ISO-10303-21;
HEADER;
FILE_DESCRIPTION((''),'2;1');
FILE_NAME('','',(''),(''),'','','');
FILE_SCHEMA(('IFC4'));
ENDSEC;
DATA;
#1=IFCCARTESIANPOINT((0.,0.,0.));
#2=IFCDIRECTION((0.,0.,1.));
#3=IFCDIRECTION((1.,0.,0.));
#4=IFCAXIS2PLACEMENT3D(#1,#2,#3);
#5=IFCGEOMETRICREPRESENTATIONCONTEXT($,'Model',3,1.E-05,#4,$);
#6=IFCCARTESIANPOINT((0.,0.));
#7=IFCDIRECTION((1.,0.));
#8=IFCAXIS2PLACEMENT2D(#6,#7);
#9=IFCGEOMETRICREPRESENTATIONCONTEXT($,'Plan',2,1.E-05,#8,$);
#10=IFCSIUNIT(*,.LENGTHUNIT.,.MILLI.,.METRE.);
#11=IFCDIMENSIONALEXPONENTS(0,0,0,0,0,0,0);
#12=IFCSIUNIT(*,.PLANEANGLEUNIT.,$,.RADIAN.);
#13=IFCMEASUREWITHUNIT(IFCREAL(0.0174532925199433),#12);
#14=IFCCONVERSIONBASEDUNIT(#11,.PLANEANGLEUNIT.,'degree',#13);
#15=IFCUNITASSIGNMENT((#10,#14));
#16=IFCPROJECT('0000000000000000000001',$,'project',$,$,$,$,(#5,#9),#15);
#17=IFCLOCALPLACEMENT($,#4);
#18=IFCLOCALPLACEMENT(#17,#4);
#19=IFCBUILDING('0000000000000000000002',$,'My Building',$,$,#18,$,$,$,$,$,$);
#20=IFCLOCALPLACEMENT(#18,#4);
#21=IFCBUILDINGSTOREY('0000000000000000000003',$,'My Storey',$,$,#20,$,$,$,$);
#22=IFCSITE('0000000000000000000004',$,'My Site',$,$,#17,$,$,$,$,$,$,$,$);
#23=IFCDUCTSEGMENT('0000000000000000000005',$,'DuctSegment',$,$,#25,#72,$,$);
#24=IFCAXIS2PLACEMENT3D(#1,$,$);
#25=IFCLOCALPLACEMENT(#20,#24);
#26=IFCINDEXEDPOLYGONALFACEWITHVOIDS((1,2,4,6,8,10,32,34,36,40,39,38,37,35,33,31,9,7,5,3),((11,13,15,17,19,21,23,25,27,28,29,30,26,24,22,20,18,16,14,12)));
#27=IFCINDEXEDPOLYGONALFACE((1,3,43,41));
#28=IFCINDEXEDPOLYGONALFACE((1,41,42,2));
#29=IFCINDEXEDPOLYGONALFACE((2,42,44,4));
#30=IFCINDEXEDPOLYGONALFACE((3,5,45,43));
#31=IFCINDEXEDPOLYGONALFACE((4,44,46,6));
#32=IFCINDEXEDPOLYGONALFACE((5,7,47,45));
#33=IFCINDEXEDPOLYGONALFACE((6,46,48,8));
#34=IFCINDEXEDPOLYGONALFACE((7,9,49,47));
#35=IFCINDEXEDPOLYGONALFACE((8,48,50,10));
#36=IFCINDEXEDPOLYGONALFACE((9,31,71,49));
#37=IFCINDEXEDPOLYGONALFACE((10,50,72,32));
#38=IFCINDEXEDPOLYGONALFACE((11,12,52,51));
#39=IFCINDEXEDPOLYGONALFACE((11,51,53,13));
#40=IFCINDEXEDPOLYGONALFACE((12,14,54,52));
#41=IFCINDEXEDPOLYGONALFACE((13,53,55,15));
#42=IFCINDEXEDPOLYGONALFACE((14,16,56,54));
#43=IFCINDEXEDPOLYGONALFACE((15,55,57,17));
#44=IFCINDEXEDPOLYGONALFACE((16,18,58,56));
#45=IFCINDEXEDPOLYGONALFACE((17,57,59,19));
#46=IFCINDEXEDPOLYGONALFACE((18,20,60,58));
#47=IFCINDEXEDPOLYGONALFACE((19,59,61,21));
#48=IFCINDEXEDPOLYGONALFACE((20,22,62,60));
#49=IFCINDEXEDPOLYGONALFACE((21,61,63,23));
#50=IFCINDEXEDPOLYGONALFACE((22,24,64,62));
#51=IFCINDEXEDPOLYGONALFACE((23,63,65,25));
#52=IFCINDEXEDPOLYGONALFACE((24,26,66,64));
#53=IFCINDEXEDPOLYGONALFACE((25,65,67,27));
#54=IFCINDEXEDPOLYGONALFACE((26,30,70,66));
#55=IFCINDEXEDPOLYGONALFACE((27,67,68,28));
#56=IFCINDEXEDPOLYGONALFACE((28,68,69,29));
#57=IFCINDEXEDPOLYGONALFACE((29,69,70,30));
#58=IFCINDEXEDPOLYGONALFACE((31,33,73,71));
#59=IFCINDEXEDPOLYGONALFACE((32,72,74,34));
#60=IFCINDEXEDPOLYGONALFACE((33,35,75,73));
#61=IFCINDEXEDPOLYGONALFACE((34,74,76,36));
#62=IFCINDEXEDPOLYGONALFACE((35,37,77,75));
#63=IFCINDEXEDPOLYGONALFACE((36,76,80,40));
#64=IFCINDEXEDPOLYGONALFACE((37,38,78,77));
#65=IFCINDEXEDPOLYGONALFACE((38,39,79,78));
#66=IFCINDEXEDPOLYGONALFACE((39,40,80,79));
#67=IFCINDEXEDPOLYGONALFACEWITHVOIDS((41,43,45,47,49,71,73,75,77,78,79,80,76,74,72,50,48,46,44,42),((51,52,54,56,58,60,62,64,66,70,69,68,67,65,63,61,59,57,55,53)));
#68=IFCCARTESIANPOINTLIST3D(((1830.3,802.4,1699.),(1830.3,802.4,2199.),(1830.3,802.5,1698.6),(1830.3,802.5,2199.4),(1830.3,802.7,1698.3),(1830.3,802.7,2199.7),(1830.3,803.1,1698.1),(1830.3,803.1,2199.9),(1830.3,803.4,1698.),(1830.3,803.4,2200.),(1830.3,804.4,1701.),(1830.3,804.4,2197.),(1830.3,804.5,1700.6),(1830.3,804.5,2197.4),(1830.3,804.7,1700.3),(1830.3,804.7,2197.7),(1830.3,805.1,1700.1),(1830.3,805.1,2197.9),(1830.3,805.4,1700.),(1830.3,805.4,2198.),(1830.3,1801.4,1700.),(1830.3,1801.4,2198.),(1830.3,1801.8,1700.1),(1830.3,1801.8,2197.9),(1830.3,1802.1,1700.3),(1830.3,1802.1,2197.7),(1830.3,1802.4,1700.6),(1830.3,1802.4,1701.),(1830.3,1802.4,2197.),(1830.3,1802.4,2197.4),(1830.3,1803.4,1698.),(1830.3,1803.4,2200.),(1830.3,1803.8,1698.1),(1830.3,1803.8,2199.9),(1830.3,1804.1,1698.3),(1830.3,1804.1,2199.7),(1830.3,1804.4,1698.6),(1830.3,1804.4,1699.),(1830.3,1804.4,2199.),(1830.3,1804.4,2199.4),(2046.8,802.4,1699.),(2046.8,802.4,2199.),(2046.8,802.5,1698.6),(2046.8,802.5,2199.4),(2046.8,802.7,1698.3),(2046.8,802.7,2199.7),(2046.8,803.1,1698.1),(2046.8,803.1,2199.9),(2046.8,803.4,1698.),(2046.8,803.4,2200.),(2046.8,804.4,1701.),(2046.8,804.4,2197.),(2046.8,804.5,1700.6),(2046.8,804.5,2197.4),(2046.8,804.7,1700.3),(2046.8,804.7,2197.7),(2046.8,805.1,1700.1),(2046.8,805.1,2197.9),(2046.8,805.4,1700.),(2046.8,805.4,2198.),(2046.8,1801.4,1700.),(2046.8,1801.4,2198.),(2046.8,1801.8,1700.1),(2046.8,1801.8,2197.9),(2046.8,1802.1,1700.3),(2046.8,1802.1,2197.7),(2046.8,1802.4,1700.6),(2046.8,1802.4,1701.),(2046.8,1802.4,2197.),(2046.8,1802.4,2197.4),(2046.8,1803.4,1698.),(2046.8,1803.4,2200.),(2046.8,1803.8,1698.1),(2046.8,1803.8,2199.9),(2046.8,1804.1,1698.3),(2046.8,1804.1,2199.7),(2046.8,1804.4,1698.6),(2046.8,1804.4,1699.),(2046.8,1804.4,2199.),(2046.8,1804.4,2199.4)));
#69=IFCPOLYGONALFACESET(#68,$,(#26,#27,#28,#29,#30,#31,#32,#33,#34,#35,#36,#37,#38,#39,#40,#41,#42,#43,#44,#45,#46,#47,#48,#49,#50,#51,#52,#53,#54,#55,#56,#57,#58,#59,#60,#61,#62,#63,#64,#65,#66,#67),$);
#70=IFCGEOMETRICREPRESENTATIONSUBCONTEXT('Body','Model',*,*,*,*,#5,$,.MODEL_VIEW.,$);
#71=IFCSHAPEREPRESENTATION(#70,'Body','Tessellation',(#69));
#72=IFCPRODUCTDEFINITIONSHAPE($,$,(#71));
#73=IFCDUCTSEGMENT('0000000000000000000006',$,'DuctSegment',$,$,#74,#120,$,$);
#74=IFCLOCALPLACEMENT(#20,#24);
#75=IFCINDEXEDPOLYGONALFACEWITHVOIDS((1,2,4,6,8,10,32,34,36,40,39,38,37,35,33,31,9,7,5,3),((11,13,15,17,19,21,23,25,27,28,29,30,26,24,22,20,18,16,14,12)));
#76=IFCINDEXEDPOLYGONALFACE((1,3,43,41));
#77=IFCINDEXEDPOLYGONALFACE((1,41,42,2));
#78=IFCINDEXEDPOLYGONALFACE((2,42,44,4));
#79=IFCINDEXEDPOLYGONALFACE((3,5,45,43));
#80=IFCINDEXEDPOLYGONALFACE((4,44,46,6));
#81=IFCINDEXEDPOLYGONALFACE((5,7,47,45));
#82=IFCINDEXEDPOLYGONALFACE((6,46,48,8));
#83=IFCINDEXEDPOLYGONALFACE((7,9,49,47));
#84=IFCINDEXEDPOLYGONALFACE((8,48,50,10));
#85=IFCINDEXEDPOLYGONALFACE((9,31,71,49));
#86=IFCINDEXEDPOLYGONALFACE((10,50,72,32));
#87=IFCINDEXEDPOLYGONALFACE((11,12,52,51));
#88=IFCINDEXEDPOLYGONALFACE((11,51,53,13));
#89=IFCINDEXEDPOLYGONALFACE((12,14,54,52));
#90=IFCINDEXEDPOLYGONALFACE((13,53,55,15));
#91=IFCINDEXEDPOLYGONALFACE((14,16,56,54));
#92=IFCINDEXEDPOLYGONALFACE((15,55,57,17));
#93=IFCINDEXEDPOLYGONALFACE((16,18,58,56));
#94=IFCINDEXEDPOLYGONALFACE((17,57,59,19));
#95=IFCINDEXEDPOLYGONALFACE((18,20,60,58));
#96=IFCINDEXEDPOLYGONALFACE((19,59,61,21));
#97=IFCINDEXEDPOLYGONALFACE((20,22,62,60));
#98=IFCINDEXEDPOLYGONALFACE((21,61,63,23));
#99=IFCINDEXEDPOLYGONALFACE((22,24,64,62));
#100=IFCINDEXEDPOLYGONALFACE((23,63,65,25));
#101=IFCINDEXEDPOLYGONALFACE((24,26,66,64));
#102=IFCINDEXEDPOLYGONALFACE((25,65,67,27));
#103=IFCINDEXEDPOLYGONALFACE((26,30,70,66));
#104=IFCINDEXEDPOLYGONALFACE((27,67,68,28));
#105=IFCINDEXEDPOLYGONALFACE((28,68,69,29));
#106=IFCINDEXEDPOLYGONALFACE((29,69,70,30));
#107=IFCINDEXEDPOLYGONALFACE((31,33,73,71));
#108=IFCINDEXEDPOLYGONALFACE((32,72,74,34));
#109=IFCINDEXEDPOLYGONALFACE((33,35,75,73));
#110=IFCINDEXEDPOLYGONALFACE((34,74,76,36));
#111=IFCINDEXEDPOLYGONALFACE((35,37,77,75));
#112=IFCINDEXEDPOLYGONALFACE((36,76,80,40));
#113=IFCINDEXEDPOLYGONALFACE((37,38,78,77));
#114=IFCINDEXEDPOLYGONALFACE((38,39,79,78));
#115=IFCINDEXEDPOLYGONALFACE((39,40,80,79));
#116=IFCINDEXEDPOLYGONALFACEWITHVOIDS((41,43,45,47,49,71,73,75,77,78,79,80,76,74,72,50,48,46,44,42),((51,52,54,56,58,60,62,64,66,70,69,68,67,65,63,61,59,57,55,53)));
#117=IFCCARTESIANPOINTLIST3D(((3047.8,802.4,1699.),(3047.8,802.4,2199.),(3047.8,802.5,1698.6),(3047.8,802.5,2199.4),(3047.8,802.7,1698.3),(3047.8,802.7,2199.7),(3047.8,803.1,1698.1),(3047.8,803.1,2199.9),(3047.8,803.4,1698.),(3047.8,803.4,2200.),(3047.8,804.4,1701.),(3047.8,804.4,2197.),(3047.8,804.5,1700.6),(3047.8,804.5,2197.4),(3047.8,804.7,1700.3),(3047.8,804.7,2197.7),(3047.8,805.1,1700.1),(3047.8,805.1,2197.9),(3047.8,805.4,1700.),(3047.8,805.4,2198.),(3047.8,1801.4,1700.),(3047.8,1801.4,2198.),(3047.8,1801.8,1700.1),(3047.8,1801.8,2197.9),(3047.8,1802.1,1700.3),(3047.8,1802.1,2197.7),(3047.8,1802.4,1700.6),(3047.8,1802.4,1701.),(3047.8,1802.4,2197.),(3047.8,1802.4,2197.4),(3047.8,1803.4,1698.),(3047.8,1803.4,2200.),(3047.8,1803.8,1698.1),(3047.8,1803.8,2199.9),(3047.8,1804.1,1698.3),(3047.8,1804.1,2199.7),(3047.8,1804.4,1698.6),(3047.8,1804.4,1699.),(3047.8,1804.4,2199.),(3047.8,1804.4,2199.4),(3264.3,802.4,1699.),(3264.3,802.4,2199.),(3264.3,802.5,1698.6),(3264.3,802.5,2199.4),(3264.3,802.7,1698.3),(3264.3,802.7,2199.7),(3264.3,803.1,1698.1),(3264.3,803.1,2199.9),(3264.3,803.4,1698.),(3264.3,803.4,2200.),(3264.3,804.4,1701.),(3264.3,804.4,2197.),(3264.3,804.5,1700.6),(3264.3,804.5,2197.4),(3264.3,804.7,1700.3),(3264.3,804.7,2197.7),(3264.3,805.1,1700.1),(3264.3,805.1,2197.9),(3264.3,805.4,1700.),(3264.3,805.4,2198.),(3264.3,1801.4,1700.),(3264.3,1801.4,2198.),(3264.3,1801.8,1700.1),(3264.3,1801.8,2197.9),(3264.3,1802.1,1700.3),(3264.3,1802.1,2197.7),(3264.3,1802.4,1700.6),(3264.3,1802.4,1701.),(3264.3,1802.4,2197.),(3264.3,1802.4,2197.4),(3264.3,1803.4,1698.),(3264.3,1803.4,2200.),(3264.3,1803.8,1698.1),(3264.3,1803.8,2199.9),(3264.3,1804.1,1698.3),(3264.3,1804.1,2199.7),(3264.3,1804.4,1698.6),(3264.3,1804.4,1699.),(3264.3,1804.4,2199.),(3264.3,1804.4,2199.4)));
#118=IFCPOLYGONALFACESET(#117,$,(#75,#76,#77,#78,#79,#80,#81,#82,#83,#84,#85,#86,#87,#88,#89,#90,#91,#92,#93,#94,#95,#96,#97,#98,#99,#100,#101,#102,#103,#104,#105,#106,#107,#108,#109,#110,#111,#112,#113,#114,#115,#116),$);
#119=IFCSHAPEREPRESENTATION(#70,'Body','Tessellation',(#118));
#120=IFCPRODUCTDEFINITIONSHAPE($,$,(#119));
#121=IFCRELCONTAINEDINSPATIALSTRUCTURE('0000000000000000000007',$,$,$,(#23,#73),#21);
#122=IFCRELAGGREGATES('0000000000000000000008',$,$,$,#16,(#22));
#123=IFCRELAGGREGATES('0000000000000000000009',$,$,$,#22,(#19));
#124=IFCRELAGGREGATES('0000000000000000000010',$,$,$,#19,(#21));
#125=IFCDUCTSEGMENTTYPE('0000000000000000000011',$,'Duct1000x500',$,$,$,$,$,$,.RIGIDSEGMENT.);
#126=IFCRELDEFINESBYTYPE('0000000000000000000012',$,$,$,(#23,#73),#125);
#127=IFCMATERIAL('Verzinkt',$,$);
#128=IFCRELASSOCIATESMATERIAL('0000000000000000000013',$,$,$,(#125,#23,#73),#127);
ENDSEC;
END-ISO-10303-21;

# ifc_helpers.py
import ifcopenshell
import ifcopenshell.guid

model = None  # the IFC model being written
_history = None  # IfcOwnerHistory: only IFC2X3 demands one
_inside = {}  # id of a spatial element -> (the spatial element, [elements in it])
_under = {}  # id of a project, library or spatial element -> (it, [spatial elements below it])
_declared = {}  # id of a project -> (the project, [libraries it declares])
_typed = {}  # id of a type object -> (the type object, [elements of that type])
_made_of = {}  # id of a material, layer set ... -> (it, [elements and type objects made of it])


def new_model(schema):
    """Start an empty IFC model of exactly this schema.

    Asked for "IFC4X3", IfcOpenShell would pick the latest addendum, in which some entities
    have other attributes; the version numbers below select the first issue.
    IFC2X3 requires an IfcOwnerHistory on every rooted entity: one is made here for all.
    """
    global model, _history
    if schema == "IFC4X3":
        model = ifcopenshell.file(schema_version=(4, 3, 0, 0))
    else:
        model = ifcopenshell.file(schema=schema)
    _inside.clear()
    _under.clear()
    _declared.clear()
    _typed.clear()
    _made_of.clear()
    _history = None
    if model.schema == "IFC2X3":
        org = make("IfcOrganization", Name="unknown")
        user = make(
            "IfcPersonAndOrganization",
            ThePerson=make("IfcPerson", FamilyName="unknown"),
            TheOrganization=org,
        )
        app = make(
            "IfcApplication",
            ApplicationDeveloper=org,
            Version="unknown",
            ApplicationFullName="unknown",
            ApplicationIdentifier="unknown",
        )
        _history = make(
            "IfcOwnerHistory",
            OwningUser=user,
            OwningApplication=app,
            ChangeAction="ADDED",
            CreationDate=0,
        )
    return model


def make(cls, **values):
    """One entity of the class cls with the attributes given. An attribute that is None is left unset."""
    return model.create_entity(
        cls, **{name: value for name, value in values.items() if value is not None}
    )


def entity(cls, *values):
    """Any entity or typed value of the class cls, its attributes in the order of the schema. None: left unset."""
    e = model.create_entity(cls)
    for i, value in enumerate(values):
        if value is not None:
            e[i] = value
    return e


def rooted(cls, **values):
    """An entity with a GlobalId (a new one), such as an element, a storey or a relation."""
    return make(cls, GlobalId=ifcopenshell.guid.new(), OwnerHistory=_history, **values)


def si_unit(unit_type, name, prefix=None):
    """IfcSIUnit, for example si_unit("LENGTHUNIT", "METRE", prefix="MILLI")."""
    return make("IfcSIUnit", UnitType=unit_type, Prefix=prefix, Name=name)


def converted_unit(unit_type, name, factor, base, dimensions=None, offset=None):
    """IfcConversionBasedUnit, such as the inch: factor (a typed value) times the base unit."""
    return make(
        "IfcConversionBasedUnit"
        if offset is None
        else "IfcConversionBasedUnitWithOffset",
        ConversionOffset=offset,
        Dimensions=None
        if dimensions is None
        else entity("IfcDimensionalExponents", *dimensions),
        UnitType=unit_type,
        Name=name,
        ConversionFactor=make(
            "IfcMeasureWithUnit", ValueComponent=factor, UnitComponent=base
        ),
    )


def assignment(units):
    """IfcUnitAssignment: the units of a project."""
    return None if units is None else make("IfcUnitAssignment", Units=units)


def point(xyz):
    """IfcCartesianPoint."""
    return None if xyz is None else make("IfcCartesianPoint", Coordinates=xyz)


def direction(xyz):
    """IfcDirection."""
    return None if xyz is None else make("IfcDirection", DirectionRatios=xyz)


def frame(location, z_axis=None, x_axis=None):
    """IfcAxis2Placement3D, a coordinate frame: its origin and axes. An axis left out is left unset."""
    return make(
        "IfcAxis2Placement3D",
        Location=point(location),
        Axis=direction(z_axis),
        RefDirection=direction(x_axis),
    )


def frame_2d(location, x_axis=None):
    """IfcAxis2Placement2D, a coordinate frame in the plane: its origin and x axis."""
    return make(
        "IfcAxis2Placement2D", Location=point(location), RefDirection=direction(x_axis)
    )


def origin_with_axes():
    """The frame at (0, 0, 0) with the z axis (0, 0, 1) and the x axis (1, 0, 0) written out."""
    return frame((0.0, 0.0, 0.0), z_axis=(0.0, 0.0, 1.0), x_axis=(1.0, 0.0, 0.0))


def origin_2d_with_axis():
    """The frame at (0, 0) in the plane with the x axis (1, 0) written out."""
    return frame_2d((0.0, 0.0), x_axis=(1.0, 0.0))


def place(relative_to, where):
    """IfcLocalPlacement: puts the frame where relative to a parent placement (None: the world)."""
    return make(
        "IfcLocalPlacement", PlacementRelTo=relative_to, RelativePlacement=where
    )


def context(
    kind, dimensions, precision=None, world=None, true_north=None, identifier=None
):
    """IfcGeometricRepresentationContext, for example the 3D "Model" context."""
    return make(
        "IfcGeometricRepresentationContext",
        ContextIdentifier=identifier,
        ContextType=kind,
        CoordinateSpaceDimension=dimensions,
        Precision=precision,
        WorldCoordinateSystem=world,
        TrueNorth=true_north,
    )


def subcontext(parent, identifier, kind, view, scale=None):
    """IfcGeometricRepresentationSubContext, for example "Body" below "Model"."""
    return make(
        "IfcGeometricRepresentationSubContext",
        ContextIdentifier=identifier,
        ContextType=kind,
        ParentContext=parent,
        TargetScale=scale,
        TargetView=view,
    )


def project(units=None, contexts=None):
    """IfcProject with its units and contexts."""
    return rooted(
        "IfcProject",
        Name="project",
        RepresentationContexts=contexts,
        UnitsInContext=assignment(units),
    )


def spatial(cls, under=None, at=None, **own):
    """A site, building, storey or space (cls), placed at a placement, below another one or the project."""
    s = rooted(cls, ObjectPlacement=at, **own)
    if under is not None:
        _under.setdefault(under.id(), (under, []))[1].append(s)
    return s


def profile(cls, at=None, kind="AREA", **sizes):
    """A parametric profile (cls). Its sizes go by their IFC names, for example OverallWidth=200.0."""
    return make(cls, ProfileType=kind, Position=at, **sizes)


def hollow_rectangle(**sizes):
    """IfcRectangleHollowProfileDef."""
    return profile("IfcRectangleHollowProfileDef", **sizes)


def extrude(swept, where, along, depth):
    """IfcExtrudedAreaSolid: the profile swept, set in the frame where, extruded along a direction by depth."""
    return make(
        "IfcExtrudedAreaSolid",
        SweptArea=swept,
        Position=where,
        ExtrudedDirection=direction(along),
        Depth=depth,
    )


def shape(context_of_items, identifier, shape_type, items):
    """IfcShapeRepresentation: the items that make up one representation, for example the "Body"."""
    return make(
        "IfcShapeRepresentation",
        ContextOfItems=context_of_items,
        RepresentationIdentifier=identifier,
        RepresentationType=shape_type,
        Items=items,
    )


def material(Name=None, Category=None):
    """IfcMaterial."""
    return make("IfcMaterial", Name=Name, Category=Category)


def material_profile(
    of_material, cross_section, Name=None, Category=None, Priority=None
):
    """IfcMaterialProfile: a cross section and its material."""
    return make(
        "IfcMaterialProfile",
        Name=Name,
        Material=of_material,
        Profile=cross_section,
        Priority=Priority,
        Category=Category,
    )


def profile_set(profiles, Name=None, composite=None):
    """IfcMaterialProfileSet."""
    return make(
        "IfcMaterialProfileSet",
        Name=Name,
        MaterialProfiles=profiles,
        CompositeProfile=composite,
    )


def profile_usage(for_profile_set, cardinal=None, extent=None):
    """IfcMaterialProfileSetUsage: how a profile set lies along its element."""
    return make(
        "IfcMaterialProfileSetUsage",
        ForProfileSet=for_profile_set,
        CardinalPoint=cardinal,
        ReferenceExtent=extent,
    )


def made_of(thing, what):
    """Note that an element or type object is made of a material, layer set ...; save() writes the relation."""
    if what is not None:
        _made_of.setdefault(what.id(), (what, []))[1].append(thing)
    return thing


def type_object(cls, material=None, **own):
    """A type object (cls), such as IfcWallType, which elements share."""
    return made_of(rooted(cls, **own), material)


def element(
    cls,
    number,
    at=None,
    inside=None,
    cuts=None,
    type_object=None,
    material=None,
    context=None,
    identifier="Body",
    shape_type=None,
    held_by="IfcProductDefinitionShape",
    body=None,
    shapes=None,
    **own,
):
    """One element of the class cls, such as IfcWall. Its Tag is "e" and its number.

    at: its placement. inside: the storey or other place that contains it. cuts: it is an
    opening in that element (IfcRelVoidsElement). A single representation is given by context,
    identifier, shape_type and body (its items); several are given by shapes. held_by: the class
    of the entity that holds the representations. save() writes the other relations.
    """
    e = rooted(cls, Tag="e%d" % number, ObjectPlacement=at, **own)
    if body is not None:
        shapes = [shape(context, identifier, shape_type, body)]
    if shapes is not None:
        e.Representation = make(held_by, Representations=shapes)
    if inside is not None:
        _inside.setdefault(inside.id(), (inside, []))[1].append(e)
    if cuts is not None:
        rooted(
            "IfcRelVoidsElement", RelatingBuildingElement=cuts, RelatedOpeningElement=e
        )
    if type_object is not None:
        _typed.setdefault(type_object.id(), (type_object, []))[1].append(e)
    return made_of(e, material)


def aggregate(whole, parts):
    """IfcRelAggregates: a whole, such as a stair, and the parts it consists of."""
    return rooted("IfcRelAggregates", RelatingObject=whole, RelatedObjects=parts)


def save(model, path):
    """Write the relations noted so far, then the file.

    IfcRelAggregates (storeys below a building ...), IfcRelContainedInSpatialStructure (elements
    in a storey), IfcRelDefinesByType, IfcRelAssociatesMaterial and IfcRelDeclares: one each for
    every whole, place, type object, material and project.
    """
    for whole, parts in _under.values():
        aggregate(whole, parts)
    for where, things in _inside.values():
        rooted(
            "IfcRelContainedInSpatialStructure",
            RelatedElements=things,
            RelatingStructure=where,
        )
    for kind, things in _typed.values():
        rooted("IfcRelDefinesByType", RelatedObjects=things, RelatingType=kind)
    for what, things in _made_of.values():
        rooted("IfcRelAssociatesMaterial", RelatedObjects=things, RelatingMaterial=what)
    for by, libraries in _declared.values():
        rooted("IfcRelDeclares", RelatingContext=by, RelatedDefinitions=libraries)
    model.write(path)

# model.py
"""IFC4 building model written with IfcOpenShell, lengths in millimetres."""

from ifc_helpers import new_model, entity, si_unit, converted_unit, frame, origin_with_axes, origin_2d_with_axis, place, context, subcontext, project, spatial, hollow_rectangle, extrude, material, material_profile, profile_set, profile_usage, type_object, element, save


model = new_model("IFC4")

# Units and contexts
model_context = context("Model", 3, precision=1e-05, world=origin_with_axes())
plan_context = context("Plan", 2, precision=1e-05, world=origin_2d_with_axis())
body_context = subcontext(model_context, "Body", "Model", "MODEL_VIEW")
ifc_project = project(units=[si_unit("LENGTHUNIT", "METRE", prefix="MILLI"), converted_unit("PLANEANGLEUNIT", "degree", entity("IfcReal", 0.0174532925199433), si_unit("PLANEANGLEUNIT", "RADIAN"), dimensions=[0, 0, 0, 0, 0, 0, 0])], contexts=[model_context, plan_context])

# Site, building, storey
site_placement = place(None, origin_with_axes())
site = spatial("IfcSite", under=ifc_project, at=site_placement, Name="My Site")
building_placement = place(site_placement, origin_with_axes())
building = spatial("IfcBuilding", under=site, at=building_placement, Name="My Building")
storey_placement = place(building_placement, origin_with_axes())
storey = spatial("IfcBuildingStorey", under=building, at=storey_placement, Name="My Storey")

# Shared definitions
ifc_material = material(Name="Verzinkt")

# Duct segments
ifc_material_profile_1 = material_profile(ifc_material, hollow_rectangle(XDim=1002.0, YDim=502.0, WallThickness=2.0, InnerFilletRadius=1.0, OuterFilletRadius=1.0))
ifc_profile_set_1 = profile_set([ifc_material_profile_1])
duct_segment_type_1 = type_object("IfcDuctSegmentType", Name="Duct1000x500", PredefinedType="RIGIDSEGMENT", material=ifc_profile_set_1)
ifc_profile_usage_1 = profile_usage(ifc_profile_set_1, cardinal=5)
duct_segment_1_placement = place(storey_placement, frame((2046.8, 1303.4, 1949.0), z_axis=(-1.0, 0.0, 0.0), x_axis=(0.0, -1.0, 0.0)))
element("IfcDuctSegment", 1, at=duct_segment_1_placement, inside=storey, type_object=duct_segment_type_1, material=ifc_profile_usage_1, Name="DuctSegment", context=body_context, shape_type="SweptSolid", body=[
    extrude(hollow_rectangle(XDim=1002.0, YDim=502.0, WallThickness=2.0, InnerFilletRadius=1.0, OuterFilletRadius=1.0), origin_with_axes(), (0.0, 0.0, 1.0), 216.5),
])
ifc_profile_usage_2 = profile_usage(ifc_profile_set_1, cardinal=5)
duct_segment_2_placement = place(storey_placement, frame((3264.3, 1303.4, 1949.0), z_axis=(-1.0, 0.0, 0.0), x_axis=(0.0, -1.0, 0.0)))
element("IfcDuctSegment", 2, at=duct_segment_2_placement, inside=storey, type_object=duct_segment_type_1, material=ifc_profile_usage_2, Name="DuctSegment", context=body_context, shape_type="SweptSolid", body=[
    extrude(hollow_rectangle(XDim=1002.0, YDim=502.0, WallThickness=2.0, InnerFilletRadius=1.0, OuterFilletRadius=1.0), origin_with_axes(), (0.0, 0.0, 1.0), 216.5),
])

save(model, "model.ifc")
